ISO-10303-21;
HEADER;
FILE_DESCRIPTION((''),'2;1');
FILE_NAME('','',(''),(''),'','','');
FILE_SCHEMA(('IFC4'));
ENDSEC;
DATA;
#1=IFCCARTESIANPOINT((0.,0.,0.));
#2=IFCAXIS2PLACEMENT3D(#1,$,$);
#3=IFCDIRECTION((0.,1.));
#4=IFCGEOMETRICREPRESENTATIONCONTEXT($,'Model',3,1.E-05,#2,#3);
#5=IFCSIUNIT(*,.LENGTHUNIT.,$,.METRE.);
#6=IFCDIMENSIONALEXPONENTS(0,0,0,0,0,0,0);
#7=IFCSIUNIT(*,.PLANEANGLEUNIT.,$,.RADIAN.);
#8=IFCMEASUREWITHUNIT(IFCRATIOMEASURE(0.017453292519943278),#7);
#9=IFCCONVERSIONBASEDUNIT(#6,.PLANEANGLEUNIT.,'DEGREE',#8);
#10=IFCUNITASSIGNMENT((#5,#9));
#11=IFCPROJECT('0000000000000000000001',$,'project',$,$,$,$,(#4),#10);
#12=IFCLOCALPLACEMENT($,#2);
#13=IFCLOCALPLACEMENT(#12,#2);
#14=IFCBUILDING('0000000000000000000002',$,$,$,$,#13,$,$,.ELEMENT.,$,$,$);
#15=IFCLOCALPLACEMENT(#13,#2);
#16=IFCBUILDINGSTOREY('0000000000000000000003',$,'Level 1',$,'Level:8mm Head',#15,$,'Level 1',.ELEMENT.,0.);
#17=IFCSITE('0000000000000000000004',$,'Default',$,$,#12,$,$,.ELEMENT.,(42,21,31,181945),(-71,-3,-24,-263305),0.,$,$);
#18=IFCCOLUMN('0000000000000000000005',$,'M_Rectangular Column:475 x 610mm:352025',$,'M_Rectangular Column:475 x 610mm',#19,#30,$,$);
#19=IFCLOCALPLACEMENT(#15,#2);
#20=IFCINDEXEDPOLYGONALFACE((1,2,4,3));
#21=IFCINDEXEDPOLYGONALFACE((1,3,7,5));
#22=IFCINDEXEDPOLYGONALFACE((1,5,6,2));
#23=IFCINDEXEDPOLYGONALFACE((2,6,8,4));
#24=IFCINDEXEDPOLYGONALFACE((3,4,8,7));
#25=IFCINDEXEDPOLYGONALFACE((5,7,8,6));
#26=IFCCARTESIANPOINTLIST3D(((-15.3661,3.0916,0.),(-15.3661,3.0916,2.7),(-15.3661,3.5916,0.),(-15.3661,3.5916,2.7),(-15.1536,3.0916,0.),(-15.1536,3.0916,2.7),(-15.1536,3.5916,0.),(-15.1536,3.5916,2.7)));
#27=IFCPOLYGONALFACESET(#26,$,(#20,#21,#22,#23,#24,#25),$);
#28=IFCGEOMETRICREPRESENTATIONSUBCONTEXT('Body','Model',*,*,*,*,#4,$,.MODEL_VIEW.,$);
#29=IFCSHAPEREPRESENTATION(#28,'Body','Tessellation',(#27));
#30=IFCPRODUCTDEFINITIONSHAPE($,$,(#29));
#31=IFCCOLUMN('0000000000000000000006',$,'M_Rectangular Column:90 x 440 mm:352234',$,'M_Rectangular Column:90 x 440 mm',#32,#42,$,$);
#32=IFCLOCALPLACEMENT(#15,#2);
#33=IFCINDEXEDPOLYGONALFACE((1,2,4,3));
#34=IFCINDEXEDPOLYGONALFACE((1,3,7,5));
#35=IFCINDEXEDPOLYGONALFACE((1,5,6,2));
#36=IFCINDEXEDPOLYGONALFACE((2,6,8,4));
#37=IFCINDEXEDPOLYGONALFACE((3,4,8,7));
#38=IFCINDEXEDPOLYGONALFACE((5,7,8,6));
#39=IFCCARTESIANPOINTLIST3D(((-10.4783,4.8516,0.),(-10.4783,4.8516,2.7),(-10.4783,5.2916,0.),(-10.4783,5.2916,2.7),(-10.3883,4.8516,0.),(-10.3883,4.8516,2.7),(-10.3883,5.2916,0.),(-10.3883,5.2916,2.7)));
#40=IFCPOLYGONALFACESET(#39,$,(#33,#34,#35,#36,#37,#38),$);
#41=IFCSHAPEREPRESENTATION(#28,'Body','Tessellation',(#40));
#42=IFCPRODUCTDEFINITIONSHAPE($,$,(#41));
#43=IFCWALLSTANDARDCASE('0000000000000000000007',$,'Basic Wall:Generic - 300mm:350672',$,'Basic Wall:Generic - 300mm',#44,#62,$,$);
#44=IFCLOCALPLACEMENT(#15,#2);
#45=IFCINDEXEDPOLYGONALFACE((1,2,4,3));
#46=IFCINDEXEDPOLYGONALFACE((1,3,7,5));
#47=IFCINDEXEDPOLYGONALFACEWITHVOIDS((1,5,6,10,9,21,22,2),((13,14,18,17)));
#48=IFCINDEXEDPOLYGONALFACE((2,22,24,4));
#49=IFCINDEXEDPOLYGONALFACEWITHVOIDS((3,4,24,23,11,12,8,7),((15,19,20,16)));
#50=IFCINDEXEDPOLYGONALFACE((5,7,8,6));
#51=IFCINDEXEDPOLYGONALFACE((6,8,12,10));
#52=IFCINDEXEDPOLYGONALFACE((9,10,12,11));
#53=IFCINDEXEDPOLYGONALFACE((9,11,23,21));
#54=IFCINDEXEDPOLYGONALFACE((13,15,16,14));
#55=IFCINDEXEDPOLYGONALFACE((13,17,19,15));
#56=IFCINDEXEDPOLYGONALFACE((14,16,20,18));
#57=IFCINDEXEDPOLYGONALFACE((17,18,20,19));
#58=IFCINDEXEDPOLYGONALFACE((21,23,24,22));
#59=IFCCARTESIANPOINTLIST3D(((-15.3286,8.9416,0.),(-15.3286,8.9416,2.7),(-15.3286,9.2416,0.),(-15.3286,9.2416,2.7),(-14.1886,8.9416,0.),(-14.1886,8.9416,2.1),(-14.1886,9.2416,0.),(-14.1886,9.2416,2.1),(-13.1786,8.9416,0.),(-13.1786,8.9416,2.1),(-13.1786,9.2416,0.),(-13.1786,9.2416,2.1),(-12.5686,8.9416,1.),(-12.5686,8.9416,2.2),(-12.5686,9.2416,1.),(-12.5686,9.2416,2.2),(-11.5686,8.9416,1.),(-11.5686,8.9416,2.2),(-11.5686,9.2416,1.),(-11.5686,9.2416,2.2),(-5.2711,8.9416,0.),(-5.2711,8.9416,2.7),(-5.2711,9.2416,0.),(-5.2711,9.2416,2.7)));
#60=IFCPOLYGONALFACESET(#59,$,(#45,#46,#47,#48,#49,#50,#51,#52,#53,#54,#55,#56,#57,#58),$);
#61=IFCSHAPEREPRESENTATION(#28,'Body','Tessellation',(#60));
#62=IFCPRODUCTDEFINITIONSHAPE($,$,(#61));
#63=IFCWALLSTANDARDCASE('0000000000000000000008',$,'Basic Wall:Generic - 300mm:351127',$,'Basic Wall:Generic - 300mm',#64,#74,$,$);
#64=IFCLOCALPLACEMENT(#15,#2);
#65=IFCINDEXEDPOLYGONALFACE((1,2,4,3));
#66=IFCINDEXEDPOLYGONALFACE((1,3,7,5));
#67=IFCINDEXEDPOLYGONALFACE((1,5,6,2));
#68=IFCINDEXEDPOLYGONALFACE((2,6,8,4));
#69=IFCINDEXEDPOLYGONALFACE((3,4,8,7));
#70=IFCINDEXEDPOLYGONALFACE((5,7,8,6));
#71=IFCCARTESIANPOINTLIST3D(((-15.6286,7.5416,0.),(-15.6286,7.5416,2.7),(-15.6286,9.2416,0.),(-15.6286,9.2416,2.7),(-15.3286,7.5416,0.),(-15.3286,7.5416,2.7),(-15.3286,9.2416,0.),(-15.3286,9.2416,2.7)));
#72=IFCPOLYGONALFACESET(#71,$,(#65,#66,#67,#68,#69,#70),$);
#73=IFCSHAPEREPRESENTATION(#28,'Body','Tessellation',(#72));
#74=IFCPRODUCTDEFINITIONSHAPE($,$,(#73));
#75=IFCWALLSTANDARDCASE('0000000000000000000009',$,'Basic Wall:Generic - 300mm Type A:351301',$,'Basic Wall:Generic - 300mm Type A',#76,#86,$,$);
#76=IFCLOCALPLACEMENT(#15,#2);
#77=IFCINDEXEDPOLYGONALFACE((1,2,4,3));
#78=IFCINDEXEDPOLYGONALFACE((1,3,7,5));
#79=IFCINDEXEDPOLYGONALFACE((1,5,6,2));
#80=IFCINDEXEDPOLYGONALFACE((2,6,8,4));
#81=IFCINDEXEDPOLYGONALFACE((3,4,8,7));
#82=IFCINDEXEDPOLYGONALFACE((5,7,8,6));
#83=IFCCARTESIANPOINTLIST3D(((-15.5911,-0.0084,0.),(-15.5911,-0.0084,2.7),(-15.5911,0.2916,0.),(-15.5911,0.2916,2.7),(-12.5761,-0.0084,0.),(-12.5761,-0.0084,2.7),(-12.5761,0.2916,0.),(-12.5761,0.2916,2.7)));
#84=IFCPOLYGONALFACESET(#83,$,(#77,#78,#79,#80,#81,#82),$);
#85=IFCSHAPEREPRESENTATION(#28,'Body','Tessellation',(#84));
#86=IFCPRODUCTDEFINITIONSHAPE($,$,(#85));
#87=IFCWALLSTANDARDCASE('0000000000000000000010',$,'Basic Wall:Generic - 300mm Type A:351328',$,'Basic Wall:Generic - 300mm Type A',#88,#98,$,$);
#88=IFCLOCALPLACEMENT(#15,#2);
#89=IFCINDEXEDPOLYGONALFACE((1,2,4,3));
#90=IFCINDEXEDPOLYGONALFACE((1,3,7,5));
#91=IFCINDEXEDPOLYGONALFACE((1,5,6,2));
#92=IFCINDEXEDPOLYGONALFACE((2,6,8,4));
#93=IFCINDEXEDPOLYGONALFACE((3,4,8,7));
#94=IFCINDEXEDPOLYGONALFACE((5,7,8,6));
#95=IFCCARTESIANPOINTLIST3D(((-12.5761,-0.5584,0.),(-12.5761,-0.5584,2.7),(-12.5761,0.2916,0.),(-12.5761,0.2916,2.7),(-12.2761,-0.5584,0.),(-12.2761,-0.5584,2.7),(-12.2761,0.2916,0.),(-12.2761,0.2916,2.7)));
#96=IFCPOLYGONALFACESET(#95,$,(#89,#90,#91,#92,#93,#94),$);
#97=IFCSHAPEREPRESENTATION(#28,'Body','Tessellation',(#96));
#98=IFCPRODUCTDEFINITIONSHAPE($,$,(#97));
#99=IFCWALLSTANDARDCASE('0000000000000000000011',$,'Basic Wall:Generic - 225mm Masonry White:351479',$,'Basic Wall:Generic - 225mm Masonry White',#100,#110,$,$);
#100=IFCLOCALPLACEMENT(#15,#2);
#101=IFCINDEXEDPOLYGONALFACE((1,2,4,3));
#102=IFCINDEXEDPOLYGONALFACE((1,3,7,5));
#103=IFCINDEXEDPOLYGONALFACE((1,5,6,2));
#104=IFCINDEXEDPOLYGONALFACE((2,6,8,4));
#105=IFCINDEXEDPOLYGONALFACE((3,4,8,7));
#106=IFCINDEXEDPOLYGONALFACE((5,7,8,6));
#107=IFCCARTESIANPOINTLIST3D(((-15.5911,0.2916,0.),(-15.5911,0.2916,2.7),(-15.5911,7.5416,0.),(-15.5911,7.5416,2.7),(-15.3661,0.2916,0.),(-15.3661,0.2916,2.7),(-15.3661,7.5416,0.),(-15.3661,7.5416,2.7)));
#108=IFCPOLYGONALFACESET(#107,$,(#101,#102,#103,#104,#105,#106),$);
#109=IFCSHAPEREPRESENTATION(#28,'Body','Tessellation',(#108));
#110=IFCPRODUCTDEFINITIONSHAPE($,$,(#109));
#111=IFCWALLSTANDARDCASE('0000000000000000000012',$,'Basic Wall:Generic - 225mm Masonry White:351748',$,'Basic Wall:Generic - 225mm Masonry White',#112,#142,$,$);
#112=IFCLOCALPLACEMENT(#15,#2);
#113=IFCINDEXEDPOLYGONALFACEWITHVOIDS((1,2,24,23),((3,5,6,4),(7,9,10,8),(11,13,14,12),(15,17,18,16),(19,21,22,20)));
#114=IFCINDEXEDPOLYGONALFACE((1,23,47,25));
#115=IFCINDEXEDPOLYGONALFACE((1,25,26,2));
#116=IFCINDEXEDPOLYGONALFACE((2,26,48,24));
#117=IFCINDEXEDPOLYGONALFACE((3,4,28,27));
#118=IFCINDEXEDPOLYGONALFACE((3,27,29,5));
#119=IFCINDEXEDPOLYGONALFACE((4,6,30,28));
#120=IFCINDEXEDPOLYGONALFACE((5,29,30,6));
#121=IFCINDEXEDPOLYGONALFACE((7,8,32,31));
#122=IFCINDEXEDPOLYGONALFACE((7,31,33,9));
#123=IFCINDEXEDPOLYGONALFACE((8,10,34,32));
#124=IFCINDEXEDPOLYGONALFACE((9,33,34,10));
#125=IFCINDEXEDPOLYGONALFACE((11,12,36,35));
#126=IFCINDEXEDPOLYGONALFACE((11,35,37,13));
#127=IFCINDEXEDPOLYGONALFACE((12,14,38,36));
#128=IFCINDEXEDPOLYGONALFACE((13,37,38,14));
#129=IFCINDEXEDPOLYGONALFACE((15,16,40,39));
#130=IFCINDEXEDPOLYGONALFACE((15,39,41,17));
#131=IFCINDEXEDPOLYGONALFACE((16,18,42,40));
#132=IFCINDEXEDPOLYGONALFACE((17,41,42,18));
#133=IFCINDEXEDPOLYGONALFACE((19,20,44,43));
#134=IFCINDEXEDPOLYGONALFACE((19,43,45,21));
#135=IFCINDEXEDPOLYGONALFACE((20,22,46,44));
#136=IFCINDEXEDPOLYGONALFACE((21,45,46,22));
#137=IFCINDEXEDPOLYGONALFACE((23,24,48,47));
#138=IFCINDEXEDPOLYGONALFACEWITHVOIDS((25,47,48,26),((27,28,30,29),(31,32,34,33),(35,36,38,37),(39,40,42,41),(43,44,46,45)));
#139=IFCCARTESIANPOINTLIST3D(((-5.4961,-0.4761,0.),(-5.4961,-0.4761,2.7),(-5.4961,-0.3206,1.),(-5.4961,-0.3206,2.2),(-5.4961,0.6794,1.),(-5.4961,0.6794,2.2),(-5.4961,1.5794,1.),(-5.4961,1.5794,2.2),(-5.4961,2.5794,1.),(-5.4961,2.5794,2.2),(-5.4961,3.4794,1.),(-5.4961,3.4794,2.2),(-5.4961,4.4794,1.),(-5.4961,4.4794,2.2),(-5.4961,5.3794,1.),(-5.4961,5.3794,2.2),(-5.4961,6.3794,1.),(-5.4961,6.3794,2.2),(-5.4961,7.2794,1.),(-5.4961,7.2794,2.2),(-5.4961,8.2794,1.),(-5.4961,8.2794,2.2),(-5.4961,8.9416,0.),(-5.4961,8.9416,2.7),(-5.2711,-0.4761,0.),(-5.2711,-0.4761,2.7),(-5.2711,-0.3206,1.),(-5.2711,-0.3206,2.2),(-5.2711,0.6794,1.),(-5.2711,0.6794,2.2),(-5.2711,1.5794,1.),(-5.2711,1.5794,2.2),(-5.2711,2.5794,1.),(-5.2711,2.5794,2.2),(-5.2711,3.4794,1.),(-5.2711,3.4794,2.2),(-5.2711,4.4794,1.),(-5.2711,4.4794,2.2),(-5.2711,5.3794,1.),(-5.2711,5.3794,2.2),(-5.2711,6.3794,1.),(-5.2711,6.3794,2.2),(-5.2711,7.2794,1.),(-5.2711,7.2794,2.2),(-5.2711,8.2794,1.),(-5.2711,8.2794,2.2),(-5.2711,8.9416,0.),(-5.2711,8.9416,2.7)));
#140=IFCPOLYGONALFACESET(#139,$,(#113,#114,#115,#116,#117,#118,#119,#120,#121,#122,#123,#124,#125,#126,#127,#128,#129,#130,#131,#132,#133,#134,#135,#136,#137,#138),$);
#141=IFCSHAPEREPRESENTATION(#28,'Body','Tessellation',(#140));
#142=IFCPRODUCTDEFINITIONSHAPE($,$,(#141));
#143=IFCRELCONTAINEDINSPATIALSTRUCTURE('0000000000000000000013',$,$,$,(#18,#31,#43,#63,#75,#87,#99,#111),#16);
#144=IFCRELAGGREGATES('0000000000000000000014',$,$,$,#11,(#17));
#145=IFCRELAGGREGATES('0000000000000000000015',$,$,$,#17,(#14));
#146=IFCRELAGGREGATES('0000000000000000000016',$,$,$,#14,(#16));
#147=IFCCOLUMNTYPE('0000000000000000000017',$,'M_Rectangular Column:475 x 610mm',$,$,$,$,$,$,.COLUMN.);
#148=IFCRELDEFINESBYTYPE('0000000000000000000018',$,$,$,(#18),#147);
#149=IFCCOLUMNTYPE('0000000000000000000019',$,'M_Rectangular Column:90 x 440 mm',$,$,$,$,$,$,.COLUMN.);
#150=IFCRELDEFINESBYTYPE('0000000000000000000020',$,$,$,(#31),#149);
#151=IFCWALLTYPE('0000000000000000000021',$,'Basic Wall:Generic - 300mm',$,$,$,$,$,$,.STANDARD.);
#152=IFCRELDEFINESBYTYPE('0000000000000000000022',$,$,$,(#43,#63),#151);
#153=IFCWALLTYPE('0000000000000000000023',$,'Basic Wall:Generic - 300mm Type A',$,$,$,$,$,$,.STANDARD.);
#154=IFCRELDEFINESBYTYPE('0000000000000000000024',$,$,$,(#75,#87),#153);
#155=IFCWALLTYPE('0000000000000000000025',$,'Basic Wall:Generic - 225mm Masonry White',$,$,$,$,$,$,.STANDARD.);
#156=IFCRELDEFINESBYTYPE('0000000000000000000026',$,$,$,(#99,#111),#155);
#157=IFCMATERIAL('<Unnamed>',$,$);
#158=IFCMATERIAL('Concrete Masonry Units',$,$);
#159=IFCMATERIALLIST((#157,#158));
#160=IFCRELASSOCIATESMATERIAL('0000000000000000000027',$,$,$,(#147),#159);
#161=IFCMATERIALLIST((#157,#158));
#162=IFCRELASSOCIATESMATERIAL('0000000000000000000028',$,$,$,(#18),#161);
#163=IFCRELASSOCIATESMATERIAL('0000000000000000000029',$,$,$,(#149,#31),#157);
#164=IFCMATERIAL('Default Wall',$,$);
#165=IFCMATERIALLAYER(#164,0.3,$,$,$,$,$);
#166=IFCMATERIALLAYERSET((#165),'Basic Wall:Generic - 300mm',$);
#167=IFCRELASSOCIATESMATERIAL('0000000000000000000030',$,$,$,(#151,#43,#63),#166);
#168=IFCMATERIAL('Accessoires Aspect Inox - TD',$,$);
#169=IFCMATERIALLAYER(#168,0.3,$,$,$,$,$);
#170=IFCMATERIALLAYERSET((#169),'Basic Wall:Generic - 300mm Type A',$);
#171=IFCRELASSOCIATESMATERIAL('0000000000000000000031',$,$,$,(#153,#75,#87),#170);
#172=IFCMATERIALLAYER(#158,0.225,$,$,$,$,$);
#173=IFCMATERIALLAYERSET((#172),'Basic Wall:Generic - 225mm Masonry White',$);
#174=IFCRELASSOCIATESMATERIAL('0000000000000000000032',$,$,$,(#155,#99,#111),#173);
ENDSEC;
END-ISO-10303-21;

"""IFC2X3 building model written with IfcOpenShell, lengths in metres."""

from ifc_helpers import new_model, entity, si_unit, converted_unit, direction, frame, frame_2d, origin, origin_2d_with_axis, place, context, subcontext, project, spatial, rectangle, extrude, source, transform, mapped, material, material_list, layer, layer_set, layer_usage, type_object, type_shapes, element, save


model = new_model("IFC2X3")

# Units and contexts
model_context = context("Model", 3, precision=1e-05, world=origin(), true_north=direction((0.0, 1.0)))
body_context = subcontext(model_context, "Body", "Model", "MODEL_VIEW")
ifc_project = project(units=[si_unit("LENGTHUNIT", "METRE"), converted_unit("PLANEANGLEUNIT", "DEGREE", entity("IfcRatioMeasure", 0.017453292519943278), si_unit("PLANEANGLEUNIT", "RADIAN"), dimensions=[0, 0, 0, 0, 0, 0, 0])], contexts=[model_context])

# Site, building, storey
site_placement = place(None, origin())
site = spatial("IfcSite", under=ifc_project, at=site_placement, Name="Default", CompositionType="ELEMENT", RefLatitude=(42, 21, 31, 181945), RefLongitude=(-71, -3, -24, -263305), RefElevation=0.0)
building_placement = place(site_placement, origin())
building = spatial("IfcBuilding", under=site, at=building_placement, CompositionType="ELEMENT")
storey_placement = place(building_placement, origin())
storey = spatial("IfcBuildingStorey", under=building, at=storey_placement, Name="Level 1", ObjectType="Level:8mm Head", LongName="Level 1", CompositionType="ELEMENT", Elevation=0.0)

# Columns
ifc_material_1 = material(Name="<Unnamed>")
ifc_material_2 = material(Name="Concrete Masonry Units")
ifc_material_list_1 = material_list([ifc_material_1, ifc_material_2])
ifc_material_list_2 = material_list([ifc_material_1, ifc_material_2])
column_type_1 = type_object("IfcColumnType", Name="M_Rectangular Column:475 x 610mm", PredefinedType="COLUMN", material=ifc_material_list_2)
shared_shape_1 = source(origin(), body_context, "Body", "SweptSolid", [
    extrude(rectangle(XDim=0.5, YDim=0.2125, at=origin_2d_with_axis()), frame((-15.2599, 3.3416, 0.0), z_axis=(0.0, 0.0, 1.0), x_axis=(0.0, -1.0, 0.0)), (0.0, 0.0, 1.0), 2.7),
])
type_shapes(column_type_1, [shared_shape_1])
column_1_placement = place(storey_placement, origin())
element("IfcColumn", 1, at=column_1_placement, inside=storey, type_object=column_type_1, material=ifc_material_list_1, Name="M_Rectangular Column:475 x 610mm:352025", ObjectType="M_Rectangular Column:475 x 610mm", context=body_context, shape_type="MappedRepresentation", body=[
    mapped(shared_shape_1, transform((0.0, 0.0, 0.0), scale=1.0)),
])
column_type_2 = type_object("IfcColumnType", Name="M_Rectangular Column:90 x 440 mm", PredefinedType="COLUMN", material=ifc_material_1)
shared_shape_2 = source(origin(), body_context, "Body", "SweptSolid", [
    extrude(rectangle(XDim=0.44, YDim=0.09, at=frame_2d((0.0, 0.0), x_axis=(1.0, 0.0))), frame((-10.4333, 5.0716, 0.0), z_axis=(0.0, 0.0, 1.0), x_axis=(0.0, -1.0, 0.0)), (0.0, 0.0, 1.0), 2.7),
])
type_shapes(column_type_2, [shared_shape_2])
column_2_placement = place(storey_placement, origin())
element("IfcColumn", 2, at=column_2_placement, inside=storey, type_object=column_type_2, material=ifc_material_1, Name="M_Rectangular Column:90 x 440 mm:352234", ObjectType="M_Rectangular Column:90 x 440 mm", context=body_context, shape_type="MappedRepresentation", body=[
    mapped(shared_shape_2, transform((0.0, 0.0, 0.0), scale=1.0)),
])

# Wall, openings
ifc_material_3 = material(Name="Default Wall")
ifc_layer_1 = layer(ifc_material_3, 0.3)
ifc_layer_set_1 = layer_set([ifc_layer_1], Name="Basic Wall:Generic - 300mm")
ifc_layer_usage_1 = layer_usage(ifc_layer_set_1, "AXIS2", "NEGATIVE", 0.15)
wall_type_1 = type_object("IfcWallType", Name="Basic Wall:Generic - 300mm", PredefinedType="STANDARD", material=ifc_layer_set_1)
wall_1_placement = place(storey_placement, frame((-15.3286, 9.0916, 0.0)))
wall_1 = element("IfcWallStandardCase", 3, at=wall_1_placement, inside=storey, type_object=wall_type_1, material=ifc_layer_usage_1, Name="Basic Wall:Generic - 300mm:350672", ObjectType="Basic Wall:Generic - 300mm", context=body_context, shape_type="SweptSolid", body=[
    extrude(rectangle(XDim=10.0575, YDim=0.3, at=frame_2d((5.0288, 0.0), x_axis=(1.0, 0.0))), origin(), (0.0, 0.0, 1.0), 2.7),
])
opening_1_placement = place(wall_1_placement, frame((2.15, 0.15, 0.0)))
element("IfcOpeningElement", 4, at=opening_1_placement, cuts=wall_1, ObjectType="Opening", context=body_context, shape_type="SweptSolid", body=[
    extrude(rectangle(XDim=2.1, YDim=1.01, at=frame_2d((1.05, 0.505), x_axis=(1.0, 0.0))), frame((0.0, 0.0, 0.0), z_axis=(0.0, -1.0, 0.0), x_axis=(0.0, 0.0, 1.0)), (0.0, 0.0, 1.0), 0.3),
])
opening_2_placement = place(wall_1_placement, frame((3.76, 0.15, 1.0)))
element("IfcOpeningElement", 5, at=opening_2_placement, cuts=wall_1, ObjectType="Opening", context=body_context, shape_type="SweptSolid", body=[
    extrude(rectangle(XDim=1.2, YDim=1.0, at=frame_2d((0.6, 0.5), x_axis=(1.0, 0.0))), frame((0.0, 0.0, 0.0), z_axis=(0.0, -1.0, 0.0), x_axis=(0.0, 0.0, 1.0)), (0.0, 0.0, 1.0), 0.3),
])

# Walls
ifc_layer_usage_2 = layer_usage(ifc_layer_set_1, "AXIS2", "NEGATIVE", 0.15)
wall_2_placement = place(storey_placement, frame((-15.4786, 9.2416, 0.0), z_axis=(0.0, 0.0, 1.0), x_axis=(0.0, -1.0, 0.0)))
element("IfcWallStandardCase", 6, at=wall_2_placement, inside=storey, type_object=wall_type_1, material=ifc_layer_usage_2, Name="Basic Wall:Generic - 300mm:351127", ObjectType="Basic Wall:Generic - 300mm", context=body_context, shape_type="SweptSolid", body=[
    extrude(rectangle(XDim=1.7, YDim=0.3, at=frame_2d((0.85, 0.0), x_axis=(-1.0, 0.0))), origin(), (0.0, 0.0, 1.0), 2.7),
])
ifc_material_4 = material(Name="Accessoires Aspect Inox - TD")
ifc_layer_2 = layer(ifc_material_4, 0.3)
ifc_layer_set_2 = layer_set([ifc_layer_2], Name="Basic Wall:Generic - 300mm Type A")
ifc_layer_usage_3 = layer_usage(ifc_layer_set_2, "AXIS2", "NEGATIVE", 0.15)
wall_type_2 = type_object("IfcWallType", Name="Basic Wall:Generic - 300mm Type A", PredefinedType="STANDARD", material=ifc_layer_set_2)
wall_3_placement = place(storey_placement, frame((-15.5911, 0.1416, 0.0)))
element("IfcWallStandardCase", 7, at=wall_3_placement, inside=storey, type_object=wall_type_2, material=ifc_layer_usage_3, Name="Basic Wall:Generic - 300mm Type A:351301", ObjectType="Basic Wall:Generic - 300mm Type A", context=body_context, shape_type="SweptSolid", body=[
    extrude(rectangle(XDim=3.015, YDim=0.3, at=frame_2d((1.5075, 0.0), x_axis=(-1.0, 0.0))), origin(), (0.0, 0.0, 1.0), 2.7),
])
ifc_layer_usage_4 = layer_usage(ifc_layer_set_2, "AXIS2", "NEGATIVE", 0.15)
wall_4_placement = place(storey_placement, frame((-12.4261, 0.2916, 0.0), z_axis=(0.0, 0.0, 1.0), x_axis=(0.0, -1.0, 0.0)))
element("IfcWallStandardCase", 8, at=wall_4_placement, inside=storey, type_object=wall_type_2, material=ifc_layer_usage_4, Name="Basic Wall:Generic - 300mm Type A:351328", ObjectType="Basic Wall:Generic - 300mm Type A", context=body_context, shape_type="SweptSolid", body=[
    extrude(rectangle(XDim=0.85, YDim=0.3, at=frame_2d((0.425, 0.0), x_axis=(-1.0, 0.0))), origin(), (0.0, 0.0, 1.0), 2.7),
])

# Wall
ifc_layer_3 = layer(ifc_material_2, 0.225)
ifc_layer_set_3 = layer_set([ifc_layer_3], Name="Basic Wall:Generic - 225mm Masonry White")
ifc_layer_usage_5 = layer_usage(ifc_layer_set_3, "AXIS2", "NEGATIVE", 0.1125)
wall_type_3 = type_object("IfcWallType", Name="Basic Wall:Generic - 225mm Masonry White", PredefinedType="STANDARD", material=ifc_layer_set_3)
wall_5_placement = place(storey_placement, frame((-15.4786, 0.2916, 0.0), z_axis=(0.0, 0.0, 1.0), x_axis=(0.0, 1.0, 0.0)))
element("IfcWallStandardCase", 9, at=wall_5_placement, inside=storey, type_object=wall_type_3, material=ifc_layer_usage_5, Name="Basic Wall:Generic - 225mm Masonry White:351479", ObjectType="Basic Wall:Generic - 225mm Masonry White", context=body_context, shape_type="SweptSolid", body=[
    extrude(rectangle(XDim=7.25, YDim=0.225, at=frame_2d((3.625, 0.0), x_axis=(-1.0, 0.0))), origin(), (0.0, 0.0, 1.0), 2.7),
])

# Wall, openings
ifc_layer_usage_6 = layer_usage(ifc_layer_set_3, "AXIS2", "NEGATIVE", 0.1125)
wall_6_placement = place(storey_placement, frame((-5.3836, 8.9416, 0.0), z_axis=(0.0, 0.0, 1.0), x_axis=(0.0, -1.0, 0.0)))
wall_6 = element("IfcWallStandardCase", 10, at=wall_6_placement, inside=storey, type_object=wall_type_3, material=ifc_layer_usage_6, Name="Basic Wall:Generic - 225mm Masonry White:351748", ObjectType="Basic Wall:Generic - 225mm Masonry White", context=body_context, shape_type="SweptSolid", body=[
    extrude(rectangle(XDim=9.4177, YDim=0.225, at=frame_2d((4.7089, 0.0), x_axis=(-1.0, 0.0))), origin(), (0.0, 0.0, 1.0), 2.7),
])
opening_3_placement = place(wall_6_placement, frame((2.5622, -0.1125, 1.0)))
element("IfcOpeningElement", 11, at=opening_3_placement, cuts=wall_6, ObjectType="Opening", context=body_context, shape_type="SweptSolid", body=[
    extrude(rectangle(XDim=1.2, YDim=1.0, at=frame_2d((0.6, 0.5), x_axis=(1.0, 0.0))), frame((0.0, 0.0, 0.0), z_axis=(0.0, 1.0, 0.0), x_axis=(0.0, 0.0, 1.0)), (0.0, 0.0, 1.0), 0.225),
])
opening_4_placement = place(wall_6_placement, frame((4.4622, -0.1125, 1.0)))
element("IfcOpeningElement", 12, at=opening_4_placement, cuts=wall_6, ObjectType="Opening", context=body_context, shape_type="SweptSolid", body=[
    extrude(rectangle(XDim=1.2, YDim=1.0, at=frame_2d((0.6, 0.5), x_axis=(1.0, 0.0))), frame((0.0, 0.0, 0.0), z_axis=(0.0, 1.0, 0.0), x_axis=(0.0, 0.0, 1.0)), (0.0, 0.0, 1.0), 0.225),
])
opening_5_placement = place(wall_6_placement, frame((6.3622, -0.1125, 1.0)))
element("IfcOpeningElement", 13, at=opening_5_placement, cuts=wall_6, ObjectType="Opening", context=body_context, shape_type="SweptSolid", body=[
    extrude(rectangle(XDim=1.2, YDim=1.0, at=frame_2d((0.6, 0.5), x_axis=(1.0, 0.0))), frame((0.0, 0.0, 0.0), z_axis=(0.0, 1.0, 0.0), x_axis=(0.0, 0.0, 1.0)), (0.0, 0.0, 1.0), 0.225),
])
opening_6_placement = place(wall_6_placement, frame((8.2622, -0.1125, 1.0)))
element("IfcOpeningElement", 14, at=opening_6_placement, cuts=wall_6, ObjectType="Opening", context=body_context, shape_type="SweptSolid", body=[
    extrude(rectangle(XDim=1.2, YDim=1.0, at=frame_2d((0.6, 0.5), x_axis=(1.0, 0.0))), frame((0.0, 0.0, 0.0), z_axis=(0.0, 1.0, 0.0), x_axis=(0.0, 0.0, 1.0)), (0.0, 0.0, 1.0), 0.225),
])
opening_7_placement = place(wall_6_placement, frame((0.6622, -0.1125, 1.0)))
element("IfcOpeningElement", 15, at=opening_7_placement, cuts=wall_6, ObjectType="Opening", context=body_context, shape_type="SweptSolid", body=[
    extrude(rectangle(XDim=1.2, YDim=1.0, at=frame_2d((0.6, 0.5), x_axis=(1.0, 0.0))), frame((0.0, 0.0, 0.0), z_axis=(0.0, 1.0, 0.0), x_axis=(0.0, 0.0, 1.0)), (0.0, 0.0, 1.0), 0.225),
])

save(model, "model.ifc")
